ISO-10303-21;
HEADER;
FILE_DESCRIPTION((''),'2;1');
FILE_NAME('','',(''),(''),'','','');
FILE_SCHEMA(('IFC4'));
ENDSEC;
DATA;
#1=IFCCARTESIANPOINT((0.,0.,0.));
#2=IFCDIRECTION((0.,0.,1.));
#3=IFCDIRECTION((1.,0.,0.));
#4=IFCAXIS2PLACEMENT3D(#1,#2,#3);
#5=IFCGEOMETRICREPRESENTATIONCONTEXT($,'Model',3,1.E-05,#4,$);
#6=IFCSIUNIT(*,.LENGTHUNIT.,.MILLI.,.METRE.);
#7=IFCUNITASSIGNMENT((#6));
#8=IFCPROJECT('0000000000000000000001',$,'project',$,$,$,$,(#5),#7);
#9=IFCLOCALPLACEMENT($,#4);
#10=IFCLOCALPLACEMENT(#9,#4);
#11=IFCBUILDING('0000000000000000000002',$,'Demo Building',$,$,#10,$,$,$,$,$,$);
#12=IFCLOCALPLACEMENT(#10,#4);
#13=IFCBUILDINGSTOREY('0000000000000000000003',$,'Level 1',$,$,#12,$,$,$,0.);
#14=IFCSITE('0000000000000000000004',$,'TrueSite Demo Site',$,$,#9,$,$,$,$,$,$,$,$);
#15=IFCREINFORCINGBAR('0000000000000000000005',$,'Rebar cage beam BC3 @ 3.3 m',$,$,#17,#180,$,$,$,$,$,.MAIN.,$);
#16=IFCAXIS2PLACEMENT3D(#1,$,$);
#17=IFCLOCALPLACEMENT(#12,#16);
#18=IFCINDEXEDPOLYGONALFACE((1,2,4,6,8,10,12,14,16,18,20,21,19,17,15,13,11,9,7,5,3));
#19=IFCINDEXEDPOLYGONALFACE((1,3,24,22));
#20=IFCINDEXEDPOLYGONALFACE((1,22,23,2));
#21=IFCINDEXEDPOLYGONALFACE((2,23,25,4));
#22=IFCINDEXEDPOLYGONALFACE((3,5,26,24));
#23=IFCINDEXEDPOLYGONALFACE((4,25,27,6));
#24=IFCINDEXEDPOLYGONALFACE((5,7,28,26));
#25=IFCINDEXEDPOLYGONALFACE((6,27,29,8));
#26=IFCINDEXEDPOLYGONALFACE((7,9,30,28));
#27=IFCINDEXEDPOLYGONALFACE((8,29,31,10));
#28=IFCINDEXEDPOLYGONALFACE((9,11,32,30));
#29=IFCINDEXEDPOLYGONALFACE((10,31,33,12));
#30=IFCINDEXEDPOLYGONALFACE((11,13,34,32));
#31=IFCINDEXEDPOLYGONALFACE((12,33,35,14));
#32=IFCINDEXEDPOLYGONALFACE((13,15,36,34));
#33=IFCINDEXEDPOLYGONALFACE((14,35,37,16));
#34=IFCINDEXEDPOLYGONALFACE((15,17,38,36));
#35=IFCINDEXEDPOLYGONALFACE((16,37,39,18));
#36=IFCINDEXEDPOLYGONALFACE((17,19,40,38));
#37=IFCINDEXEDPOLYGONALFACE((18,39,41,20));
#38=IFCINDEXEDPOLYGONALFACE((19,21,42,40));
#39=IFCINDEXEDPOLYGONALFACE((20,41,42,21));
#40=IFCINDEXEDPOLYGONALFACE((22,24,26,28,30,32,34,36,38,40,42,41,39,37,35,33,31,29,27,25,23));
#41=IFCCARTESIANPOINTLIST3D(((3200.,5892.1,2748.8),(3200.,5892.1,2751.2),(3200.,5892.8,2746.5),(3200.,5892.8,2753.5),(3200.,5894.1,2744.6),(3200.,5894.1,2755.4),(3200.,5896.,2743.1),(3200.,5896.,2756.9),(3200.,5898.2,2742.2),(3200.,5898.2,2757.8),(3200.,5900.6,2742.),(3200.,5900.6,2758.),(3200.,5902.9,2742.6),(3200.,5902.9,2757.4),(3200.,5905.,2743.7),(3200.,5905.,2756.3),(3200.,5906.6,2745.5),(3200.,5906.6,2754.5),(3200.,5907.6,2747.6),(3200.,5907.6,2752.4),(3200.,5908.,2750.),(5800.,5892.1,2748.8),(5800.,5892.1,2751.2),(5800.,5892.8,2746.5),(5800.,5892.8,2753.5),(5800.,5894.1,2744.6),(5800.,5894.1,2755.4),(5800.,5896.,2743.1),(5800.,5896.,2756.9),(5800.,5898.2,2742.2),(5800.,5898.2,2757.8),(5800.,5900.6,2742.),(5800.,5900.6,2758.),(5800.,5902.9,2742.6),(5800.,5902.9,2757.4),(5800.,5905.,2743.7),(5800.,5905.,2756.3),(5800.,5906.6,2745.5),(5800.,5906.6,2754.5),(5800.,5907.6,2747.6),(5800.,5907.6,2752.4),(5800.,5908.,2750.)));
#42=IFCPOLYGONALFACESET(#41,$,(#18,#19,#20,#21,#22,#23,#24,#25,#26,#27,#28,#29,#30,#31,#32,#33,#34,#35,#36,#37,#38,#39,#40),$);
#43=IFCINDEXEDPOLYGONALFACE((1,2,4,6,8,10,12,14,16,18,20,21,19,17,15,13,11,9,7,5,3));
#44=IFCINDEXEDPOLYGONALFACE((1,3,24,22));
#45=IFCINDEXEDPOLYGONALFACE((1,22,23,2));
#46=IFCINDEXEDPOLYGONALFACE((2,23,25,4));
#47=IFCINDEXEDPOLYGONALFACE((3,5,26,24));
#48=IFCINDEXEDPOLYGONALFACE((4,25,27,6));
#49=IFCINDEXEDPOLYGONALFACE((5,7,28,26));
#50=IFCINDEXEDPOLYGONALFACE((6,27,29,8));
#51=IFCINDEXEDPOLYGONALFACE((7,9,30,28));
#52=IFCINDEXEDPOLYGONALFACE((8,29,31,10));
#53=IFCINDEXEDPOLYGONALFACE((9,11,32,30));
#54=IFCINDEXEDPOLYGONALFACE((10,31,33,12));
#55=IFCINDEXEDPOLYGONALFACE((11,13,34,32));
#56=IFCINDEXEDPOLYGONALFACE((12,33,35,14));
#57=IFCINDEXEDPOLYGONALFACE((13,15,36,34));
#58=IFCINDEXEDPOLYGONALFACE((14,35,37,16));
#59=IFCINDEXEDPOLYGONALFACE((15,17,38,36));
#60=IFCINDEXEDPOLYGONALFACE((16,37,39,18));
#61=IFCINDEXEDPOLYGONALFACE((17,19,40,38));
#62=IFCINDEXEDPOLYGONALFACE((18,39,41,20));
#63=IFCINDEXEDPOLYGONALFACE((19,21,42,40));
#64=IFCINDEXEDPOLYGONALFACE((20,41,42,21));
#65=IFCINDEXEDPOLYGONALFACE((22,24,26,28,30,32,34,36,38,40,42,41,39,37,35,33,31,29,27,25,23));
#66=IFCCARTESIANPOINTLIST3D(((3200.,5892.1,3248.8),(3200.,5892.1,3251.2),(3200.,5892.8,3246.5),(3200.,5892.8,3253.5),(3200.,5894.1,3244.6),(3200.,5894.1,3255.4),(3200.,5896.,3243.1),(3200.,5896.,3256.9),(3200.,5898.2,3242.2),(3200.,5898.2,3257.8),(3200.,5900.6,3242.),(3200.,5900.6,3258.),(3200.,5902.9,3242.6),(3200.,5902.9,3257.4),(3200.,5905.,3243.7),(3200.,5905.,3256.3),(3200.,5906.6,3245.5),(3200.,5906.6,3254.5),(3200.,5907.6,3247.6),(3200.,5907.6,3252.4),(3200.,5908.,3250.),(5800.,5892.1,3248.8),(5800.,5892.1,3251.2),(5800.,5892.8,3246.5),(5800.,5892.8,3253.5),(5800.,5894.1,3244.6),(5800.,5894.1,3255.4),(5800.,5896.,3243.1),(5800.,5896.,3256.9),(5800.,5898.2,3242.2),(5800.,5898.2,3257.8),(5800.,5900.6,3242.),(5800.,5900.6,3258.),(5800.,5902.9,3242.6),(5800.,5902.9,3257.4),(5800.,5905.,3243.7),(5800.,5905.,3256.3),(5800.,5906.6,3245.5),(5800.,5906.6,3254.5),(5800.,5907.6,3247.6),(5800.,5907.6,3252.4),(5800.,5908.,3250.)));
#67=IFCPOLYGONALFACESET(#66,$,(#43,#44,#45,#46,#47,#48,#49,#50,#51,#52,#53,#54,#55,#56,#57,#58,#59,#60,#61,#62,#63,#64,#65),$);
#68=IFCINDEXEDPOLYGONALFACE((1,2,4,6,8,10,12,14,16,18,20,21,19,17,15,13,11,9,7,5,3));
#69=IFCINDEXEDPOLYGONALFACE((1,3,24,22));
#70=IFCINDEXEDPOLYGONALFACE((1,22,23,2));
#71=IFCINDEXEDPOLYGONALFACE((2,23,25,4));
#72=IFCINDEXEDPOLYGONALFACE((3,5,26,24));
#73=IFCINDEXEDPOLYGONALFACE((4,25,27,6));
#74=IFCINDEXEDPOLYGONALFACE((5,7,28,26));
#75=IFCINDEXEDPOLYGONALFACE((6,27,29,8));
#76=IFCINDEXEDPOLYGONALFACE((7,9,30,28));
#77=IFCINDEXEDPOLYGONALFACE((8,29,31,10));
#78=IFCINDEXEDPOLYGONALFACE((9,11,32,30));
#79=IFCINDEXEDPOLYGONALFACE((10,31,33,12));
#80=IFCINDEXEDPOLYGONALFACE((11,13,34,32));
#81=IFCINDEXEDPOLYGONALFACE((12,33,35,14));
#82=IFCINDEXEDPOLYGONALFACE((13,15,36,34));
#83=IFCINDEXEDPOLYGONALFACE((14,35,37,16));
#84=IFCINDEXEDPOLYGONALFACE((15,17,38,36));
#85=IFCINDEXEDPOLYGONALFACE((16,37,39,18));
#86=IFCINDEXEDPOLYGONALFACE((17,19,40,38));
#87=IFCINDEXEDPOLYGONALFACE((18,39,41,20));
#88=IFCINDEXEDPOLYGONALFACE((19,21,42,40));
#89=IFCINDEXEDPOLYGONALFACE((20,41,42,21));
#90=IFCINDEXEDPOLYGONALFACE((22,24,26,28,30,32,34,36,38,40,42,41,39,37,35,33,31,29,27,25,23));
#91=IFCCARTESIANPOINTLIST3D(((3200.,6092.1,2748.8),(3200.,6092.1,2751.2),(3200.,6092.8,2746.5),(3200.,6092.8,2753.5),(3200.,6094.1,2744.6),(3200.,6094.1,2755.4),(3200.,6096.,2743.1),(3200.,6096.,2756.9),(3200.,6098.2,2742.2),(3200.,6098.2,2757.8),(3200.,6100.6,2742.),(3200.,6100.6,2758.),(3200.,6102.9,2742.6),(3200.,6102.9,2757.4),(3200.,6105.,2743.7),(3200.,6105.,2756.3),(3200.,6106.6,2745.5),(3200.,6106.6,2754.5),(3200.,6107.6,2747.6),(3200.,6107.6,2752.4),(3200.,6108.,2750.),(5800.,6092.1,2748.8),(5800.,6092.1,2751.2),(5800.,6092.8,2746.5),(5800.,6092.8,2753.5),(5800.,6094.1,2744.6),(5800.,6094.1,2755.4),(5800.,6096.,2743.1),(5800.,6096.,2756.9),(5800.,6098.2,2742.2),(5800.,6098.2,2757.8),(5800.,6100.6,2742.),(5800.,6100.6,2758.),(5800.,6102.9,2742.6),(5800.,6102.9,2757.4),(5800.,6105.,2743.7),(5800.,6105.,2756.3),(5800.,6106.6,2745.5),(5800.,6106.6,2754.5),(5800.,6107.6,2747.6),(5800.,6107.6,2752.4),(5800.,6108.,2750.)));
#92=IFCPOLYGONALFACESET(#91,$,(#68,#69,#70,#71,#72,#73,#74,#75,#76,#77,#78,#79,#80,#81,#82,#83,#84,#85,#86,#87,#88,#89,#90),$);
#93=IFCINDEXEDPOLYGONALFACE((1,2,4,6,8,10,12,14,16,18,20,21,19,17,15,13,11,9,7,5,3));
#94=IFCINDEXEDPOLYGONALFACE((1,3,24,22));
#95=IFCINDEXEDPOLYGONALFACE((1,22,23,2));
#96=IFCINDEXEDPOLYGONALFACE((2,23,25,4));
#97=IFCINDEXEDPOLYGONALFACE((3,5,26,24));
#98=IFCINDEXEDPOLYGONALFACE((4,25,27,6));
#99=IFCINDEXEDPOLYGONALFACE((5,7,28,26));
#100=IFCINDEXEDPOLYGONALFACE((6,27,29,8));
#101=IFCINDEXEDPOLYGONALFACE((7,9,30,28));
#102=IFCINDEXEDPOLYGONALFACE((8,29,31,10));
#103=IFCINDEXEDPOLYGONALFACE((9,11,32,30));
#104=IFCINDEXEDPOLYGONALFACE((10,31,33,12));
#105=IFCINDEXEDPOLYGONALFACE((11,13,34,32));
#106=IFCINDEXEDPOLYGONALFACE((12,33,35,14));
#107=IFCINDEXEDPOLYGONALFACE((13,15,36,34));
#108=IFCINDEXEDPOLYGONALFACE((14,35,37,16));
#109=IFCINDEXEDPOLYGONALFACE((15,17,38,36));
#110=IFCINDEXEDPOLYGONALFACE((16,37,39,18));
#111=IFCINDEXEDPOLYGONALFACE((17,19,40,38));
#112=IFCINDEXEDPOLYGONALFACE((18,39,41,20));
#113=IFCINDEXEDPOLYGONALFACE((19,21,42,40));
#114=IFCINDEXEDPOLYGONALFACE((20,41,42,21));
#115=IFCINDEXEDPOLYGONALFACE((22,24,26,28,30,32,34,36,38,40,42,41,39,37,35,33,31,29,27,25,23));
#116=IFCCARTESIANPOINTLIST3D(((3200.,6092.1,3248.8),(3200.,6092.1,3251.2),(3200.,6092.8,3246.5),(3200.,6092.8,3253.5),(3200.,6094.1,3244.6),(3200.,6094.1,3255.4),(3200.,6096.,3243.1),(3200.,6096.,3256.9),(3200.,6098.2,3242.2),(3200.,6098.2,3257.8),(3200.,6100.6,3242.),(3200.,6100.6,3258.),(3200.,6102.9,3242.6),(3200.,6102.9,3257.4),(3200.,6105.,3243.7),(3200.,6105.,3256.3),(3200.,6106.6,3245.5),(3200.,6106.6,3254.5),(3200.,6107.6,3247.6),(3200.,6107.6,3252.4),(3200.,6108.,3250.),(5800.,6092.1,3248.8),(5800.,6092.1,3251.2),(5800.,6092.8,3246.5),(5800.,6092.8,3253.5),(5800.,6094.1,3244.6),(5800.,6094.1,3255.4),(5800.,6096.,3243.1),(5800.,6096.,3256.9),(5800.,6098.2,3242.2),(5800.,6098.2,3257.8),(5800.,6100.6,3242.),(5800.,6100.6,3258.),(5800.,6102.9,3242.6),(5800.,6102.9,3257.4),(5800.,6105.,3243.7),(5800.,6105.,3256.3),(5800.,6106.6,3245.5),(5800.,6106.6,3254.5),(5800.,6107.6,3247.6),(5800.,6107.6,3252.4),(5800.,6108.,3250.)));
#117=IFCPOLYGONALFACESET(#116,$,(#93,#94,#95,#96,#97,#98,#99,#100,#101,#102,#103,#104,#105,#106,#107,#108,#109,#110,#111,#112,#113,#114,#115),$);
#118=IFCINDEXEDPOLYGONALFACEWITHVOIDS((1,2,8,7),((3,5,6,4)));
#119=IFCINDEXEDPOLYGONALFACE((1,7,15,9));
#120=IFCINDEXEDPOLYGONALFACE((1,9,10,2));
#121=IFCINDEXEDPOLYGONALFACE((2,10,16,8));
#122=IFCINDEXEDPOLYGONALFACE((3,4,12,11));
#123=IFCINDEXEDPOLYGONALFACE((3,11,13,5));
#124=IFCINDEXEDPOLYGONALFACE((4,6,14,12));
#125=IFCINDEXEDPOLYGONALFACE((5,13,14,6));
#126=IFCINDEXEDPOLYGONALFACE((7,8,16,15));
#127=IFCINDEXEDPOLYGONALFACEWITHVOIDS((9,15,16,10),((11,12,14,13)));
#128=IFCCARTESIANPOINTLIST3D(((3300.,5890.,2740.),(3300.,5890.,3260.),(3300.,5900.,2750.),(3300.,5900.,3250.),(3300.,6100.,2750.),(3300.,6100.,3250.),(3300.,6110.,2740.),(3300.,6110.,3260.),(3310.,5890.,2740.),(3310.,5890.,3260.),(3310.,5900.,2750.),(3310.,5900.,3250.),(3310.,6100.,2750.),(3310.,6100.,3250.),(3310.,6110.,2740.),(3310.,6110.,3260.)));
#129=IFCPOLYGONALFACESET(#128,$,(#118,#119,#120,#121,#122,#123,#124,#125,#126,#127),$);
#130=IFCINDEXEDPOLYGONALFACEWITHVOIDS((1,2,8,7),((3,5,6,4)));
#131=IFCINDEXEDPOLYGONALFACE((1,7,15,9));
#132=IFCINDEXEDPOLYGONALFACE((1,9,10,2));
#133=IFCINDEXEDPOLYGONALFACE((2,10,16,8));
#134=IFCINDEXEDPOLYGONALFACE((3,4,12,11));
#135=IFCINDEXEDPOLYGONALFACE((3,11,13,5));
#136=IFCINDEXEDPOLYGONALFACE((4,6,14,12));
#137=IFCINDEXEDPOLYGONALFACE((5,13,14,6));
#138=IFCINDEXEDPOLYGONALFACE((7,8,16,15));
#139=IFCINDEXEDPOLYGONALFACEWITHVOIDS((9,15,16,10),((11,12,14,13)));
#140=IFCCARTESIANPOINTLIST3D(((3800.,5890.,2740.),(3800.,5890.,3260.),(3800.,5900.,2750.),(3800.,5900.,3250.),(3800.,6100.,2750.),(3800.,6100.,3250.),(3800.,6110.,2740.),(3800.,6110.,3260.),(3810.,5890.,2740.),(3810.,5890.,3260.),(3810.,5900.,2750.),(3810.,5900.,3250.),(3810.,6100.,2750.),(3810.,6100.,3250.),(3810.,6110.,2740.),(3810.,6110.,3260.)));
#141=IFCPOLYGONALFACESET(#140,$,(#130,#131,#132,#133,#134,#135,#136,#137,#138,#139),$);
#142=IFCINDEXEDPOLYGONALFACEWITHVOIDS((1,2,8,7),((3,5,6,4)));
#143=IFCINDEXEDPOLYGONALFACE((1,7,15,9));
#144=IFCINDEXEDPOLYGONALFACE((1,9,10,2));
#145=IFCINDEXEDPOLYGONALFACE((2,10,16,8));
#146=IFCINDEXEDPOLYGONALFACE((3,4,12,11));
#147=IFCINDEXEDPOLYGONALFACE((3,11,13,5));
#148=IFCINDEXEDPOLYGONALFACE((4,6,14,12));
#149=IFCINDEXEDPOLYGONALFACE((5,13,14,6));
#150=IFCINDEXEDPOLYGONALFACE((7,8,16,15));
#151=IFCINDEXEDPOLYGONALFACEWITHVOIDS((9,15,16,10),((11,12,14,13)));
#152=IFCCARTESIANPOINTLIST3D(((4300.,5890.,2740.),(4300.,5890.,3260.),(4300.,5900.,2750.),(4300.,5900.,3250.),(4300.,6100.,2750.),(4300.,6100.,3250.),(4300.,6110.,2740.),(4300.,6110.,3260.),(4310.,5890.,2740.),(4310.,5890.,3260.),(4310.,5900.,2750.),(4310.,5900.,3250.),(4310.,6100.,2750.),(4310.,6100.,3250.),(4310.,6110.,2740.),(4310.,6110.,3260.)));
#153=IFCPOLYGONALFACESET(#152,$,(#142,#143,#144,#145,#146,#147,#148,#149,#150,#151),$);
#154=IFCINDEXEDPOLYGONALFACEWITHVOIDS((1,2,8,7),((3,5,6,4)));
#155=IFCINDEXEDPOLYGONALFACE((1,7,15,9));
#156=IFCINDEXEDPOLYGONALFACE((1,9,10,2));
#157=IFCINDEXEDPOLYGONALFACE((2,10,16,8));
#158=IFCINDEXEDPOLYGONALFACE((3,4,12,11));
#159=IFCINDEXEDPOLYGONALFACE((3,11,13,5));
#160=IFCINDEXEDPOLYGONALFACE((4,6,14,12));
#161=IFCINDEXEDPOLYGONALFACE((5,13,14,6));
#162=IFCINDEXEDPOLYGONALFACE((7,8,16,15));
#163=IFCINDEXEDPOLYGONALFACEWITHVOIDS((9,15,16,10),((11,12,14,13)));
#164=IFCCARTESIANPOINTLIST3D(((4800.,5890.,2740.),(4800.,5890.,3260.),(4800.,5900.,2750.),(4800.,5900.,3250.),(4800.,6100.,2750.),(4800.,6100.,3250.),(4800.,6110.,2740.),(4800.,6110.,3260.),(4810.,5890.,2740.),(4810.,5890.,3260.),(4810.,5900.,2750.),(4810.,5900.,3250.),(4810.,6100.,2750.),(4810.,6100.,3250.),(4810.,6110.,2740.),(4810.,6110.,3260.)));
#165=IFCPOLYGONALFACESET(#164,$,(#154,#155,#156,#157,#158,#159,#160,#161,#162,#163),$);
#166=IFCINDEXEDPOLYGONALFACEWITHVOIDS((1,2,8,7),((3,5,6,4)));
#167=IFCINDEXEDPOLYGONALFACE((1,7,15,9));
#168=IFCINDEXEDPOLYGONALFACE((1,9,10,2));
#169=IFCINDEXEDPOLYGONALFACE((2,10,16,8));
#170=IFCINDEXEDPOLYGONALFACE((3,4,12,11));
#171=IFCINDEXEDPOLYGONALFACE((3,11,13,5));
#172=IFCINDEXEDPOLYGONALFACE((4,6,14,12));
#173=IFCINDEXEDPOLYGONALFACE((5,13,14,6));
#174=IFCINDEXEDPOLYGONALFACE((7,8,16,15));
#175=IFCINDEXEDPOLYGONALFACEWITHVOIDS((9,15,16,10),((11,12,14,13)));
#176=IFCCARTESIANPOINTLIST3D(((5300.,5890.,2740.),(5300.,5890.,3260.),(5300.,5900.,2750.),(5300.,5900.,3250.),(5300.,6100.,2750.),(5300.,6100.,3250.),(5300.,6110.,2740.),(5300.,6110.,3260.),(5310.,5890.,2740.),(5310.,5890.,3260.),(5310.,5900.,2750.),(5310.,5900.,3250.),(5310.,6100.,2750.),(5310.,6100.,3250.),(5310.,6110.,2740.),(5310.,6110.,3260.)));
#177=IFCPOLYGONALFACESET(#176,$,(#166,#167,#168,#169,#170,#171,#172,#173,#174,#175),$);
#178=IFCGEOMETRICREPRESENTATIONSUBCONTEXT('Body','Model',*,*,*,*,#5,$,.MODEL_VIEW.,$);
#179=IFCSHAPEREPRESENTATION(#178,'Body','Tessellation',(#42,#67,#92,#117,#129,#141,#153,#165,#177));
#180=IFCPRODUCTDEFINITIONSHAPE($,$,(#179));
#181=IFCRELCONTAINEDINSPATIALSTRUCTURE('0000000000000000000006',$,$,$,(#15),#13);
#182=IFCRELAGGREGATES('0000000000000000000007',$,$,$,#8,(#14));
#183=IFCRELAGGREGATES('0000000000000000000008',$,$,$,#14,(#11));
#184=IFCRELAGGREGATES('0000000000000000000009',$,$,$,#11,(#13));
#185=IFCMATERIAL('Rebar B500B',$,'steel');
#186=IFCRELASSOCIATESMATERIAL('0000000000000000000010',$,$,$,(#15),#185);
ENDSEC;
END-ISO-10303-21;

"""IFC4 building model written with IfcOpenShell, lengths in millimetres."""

from ifc_helpers import new_model, si_unit, frame, origin_with_axes, place, context, subcontext, project, spatial, hollow_rectangle, circle, extrude, material, element, save


model = new_model("IFC4")

# Units and contexts
model_context = context("Model", 3, precision=1e-05, world=origin_with_axes())
body_context = subcontext(model_context, "Body", "Model", "MODEL_VIEW")
ifc_project = project(units=[si_unit("LENGTHUNIT", "METRE", prefix="MILLI")], contexts=[model_context])

# Site, building, storey
site_placement = place(None, origin_with_axes())
site = spatial("IfcSite", under=ifc_project, at=site_placement, Name="TrueSite Demo Site")
building_placement = place(site_placement, origin_with_axes())
building = spatial("IfcBuilding", under=site, at=building_placement, Name="Demo Building")
storey_placement = place(building_placement, origin_with_axes())
storey = spatial("IfcBuildingStorey", under=building, at=storey_placement, Name="Level 1", Elevation=0.0)

# Reinforcing bar
ifc_material_1 = material(Name="Rebar B500B", Category="steel")
for number, where, z_axis, x_axis, name in (
    (1, (3200.0, 6000.0, 3000.0), (1.0, 0.0, 0.0), (0.0, 1.0, 0.0), "Rebar cage beam BC3 @ 3.3 m"),
):
    element("IfcReinforcingBar", number, at=place(storey_placement, frame(where, z_axis=z_axis, x_axis=x_axis)), inside=storey, material=ifc_material_1, Name=name, PredefinedType="MAIN", context=body_context, shape_type="SweptSolid", body=[
        extrude(circle(Radius=8.0), frame((-100.0, -250.0, 0.0)), (0.0, 0.0, 1.0), 2600.0),
        extrude(circle(Radius=8.0), frame((-100.0, 250.0, 0.0)), (0.0, 0.0, 1.0), 2600.0),
        extrude(circle(Radius=8.0), frame((100.0, -250.0, 0.0)), (0.0, 0.0, 1.0), 2600.0),
        extrude(circle(Radius=8.0), frame((100.0, 250.0, 0.0)), (0.0, 0.0, 1.0), 2600.0),
        extrude(hollow_rectangle(XDim=220.0, YDim=520.0, WallThickness=10.0), frame((0.0, 0.0, 100.0)), (0.0, 0.0, 1.0), 10.0),
        extrude(hollow_rectangle(XDim=220.0, YDim=520.0, WallThickness=10.0), frame((0.0, 0.0, 600.0)), (0.0, 0.0, 1.0), 10.0),
        extrude(hollow_rectangle(XDim=220.0, YDim=520.0, WallThickness=10.0), frame((0.0, 0.0, 1100.0)), (0.0, 0.0, 1.0), 10.0),
        extrude(hollow_rectangle(XDim=220.0, YDim=520.0, WallThickness=10.0), frame((0.0, 0.0, 1600.0)), (0.0, 0.0, 1.0), 10.0),
        extrude(hollow_rectangle(XDim=220.0, YDim=520.0, WallThickness=10.0), frame((0.0, 0.0, 2100.0)), (0.0, 0.0, 1.0), 10.0),
    ])

save(model, "model.ifc")
